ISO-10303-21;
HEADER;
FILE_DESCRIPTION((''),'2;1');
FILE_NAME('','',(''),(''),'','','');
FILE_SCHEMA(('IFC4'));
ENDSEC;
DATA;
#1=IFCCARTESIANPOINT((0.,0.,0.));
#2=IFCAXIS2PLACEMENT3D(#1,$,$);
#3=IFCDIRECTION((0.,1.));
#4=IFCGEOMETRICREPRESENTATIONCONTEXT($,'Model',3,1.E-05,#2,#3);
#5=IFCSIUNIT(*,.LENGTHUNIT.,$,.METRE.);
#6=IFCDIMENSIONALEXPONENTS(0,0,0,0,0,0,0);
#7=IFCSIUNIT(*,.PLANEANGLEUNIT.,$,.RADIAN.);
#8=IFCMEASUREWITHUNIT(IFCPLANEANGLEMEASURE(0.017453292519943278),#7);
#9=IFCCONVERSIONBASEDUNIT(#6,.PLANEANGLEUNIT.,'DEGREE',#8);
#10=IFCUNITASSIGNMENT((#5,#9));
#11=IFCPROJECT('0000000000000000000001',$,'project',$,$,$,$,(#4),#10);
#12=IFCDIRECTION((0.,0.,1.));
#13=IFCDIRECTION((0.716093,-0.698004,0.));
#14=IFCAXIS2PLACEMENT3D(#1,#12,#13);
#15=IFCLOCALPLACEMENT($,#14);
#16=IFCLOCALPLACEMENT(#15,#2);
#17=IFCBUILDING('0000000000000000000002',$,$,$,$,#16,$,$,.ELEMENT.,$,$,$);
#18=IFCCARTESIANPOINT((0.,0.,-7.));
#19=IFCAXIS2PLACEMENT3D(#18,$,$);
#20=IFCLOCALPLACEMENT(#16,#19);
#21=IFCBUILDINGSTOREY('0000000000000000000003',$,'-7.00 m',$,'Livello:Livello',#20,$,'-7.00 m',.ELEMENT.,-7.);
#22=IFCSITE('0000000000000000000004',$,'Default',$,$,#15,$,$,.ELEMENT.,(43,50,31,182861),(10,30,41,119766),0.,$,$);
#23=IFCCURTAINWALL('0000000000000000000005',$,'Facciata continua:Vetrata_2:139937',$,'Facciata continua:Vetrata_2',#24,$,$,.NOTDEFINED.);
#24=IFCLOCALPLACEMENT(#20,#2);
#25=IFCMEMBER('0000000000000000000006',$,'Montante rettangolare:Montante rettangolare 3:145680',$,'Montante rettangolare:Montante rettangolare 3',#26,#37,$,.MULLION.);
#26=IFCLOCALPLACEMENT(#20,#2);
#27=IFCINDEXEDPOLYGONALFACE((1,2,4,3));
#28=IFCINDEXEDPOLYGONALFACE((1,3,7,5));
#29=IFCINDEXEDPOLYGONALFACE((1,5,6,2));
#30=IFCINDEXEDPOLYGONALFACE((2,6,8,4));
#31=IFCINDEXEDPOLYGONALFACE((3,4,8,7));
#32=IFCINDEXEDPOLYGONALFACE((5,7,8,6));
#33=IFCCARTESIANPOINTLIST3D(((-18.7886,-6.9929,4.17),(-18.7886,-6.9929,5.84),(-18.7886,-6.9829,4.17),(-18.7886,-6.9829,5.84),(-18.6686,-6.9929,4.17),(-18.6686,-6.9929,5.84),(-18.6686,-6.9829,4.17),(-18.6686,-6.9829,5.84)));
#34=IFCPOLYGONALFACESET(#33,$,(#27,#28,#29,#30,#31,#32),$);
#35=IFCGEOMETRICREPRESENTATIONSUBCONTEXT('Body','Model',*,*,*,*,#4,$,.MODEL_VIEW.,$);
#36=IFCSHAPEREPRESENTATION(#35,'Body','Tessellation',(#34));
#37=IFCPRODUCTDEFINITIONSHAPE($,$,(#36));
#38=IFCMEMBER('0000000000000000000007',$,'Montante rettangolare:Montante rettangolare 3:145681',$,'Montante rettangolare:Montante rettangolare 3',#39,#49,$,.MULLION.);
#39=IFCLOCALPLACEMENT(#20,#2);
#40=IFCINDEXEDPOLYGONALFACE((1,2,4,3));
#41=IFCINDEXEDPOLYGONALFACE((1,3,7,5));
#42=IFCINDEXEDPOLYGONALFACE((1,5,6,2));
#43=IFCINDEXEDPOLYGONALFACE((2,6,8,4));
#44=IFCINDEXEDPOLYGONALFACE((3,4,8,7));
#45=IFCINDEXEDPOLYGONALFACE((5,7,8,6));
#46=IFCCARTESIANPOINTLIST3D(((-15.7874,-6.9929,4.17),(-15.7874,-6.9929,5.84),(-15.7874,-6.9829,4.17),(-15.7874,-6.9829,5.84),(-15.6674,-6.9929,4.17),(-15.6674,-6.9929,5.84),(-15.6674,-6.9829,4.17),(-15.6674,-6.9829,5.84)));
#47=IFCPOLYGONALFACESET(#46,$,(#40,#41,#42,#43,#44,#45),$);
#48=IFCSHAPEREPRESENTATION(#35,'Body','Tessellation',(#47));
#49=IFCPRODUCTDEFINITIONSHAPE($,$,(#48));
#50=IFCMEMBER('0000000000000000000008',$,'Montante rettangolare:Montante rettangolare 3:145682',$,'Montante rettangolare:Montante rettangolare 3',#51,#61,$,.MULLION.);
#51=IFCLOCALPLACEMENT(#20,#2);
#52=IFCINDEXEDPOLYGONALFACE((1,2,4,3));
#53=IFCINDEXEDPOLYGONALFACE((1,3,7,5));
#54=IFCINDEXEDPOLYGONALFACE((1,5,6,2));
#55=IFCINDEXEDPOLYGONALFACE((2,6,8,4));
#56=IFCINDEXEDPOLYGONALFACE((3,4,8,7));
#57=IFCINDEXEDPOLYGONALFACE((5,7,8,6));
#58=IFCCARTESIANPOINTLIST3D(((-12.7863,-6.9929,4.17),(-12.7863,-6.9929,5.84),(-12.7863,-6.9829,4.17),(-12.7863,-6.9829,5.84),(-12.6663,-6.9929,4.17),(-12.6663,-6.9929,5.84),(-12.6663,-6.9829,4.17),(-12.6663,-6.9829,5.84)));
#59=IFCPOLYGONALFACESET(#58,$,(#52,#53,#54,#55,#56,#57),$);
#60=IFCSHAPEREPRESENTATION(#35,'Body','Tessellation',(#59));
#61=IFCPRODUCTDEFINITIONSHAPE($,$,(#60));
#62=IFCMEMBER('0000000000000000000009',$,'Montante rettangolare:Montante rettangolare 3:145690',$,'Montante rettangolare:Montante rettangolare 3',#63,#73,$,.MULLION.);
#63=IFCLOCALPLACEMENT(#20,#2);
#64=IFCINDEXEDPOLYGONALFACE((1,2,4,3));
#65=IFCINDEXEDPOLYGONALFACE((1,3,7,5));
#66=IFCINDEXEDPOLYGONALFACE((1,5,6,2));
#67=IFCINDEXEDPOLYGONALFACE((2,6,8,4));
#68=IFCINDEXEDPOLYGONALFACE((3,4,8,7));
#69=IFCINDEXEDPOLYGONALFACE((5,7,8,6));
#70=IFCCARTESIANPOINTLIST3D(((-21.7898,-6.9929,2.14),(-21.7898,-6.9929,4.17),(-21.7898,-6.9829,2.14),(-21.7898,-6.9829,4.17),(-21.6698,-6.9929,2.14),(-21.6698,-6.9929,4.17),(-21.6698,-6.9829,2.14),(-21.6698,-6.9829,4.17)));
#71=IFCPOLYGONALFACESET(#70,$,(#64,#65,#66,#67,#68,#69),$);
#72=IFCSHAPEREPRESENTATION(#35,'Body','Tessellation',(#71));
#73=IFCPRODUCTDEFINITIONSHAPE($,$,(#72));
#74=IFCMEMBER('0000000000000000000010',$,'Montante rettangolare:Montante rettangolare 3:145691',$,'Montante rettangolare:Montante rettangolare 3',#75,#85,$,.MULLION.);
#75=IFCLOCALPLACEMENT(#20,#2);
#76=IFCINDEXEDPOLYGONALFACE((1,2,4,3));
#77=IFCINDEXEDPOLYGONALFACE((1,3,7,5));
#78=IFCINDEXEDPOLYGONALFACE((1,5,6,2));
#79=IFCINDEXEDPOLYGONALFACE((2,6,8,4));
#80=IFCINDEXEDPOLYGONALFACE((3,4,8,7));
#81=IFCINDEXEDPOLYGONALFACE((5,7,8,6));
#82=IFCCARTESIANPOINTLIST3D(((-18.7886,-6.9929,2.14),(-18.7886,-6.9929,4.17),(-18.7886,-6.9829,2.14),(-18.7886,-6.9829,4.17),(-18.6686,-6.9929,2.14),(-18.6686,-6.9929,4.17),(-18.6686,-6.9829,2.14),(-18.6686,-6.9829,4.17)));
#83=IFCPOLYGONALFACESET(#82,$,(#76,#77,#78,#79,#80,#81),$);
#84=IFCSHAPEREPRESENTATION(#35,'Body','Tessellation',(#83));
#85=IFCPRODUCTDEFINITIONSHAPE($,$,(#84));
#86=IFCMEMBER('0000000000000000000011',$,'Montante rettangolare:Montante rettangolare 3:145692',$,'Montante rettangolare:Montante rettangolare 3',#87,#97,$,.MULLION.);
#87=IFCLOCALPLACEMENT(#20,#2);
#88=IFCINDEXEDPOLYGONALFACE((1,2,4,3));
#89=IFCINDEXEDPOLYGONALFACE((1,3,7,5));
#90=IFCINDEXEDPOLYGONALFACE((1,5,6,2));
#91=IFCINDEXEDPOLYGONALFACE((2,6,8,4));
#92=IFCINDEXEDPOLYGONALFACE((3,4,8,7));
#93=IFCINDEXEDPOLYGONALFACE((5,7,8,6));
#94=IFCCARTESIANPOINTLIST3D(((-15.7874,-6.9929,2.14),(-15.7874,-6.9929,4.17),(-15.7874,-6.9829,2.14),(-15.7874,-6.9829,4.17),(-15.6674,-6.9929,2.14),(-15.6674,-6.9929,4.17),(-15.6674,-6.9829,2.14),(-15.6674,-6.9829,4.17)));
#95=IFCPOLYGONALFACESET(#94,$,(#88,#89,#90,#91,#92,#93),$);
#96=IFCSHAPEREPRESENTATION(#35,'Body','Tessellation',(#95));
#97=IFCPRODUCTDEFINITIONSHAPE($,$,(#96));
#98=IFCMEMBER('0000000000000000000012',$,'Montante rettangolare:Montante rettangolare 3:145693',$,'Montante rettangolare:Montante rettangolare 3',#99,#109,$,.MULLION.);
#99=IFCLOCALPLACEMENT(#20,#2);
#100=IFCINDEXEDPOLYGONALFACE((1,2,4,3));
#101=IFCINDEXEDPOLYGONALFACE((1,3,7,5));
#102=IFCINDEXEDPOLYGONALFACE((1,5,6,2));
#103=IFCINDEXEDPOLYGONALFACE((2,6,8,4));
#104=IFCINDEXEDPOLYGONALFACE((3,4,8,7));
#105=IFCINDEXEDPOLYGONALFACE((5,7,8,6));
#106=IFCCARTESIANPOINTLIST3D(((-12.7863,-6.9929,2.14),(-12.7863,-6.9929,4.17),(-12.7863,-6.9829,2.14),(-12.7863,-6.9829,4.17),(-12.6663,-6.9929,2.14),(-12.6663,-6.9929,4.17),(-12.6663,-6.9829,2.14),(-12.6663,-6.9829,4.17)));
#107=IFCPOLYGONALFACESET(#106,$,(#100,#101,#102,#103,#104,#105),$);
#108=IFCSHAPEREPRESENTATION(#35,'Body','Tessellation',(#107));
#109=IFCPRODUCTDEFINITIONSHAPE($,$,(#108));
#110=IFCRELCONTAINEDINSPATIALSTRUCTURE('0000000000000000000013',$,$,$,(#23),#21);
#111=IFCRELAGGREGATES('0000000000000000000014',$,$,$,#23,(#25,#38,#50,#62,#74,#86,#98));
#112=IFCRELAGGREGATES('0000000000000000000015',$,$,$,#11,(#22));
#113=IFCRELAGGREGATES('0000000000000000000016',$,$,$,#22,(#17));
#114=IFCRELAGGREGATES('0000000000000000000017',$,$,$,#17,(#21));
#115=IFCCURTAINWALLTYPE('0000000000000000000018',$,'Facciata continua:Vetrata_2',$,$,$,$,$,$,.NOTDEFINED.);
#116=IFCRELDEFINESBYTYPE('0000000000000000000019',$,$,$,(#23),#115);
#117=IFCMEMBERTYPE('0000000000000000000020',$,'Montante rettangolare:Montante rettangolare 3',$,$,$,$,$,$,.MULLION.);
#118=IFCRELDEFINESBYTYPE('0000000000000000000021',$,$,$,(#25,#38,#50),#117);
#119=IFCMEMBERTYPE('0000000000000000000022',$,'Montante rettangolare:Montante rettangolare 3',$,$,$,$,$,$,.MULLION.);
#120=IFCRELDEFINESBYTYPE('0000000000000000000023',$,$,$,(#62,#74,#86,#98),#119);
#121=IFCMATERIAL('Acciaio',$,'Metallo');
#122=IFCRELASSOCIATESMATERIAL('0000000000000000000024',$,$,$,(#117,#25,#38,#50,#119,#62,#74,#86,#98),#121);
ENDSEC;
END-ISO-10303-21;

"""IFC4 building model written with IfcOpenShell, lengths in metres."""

from ifc_helpers import new_model, entity, si_unit, converted_unit, direction, frame, origin, place, context, subcontext, project, spatial, indexed_curve, outline, extrude, source, transform, mapped, material, type_object, type_shapes, element, aggregate, save


model = new_model("IFC4")

# Units and contexts
model_context = context("Model", 3, precision=1e-05, world=origin(), true_north=direction((0.0, 1.0)))
body_context = subcontext(model_context, "Body", "Model", "MODEL_VIEW")
ifc_project = project(units=[si_unit("LENGTHUNIT", "METRE"), converted_unit("PLANEANGLEUNIT", "DEGREE", entity("IfcPlaneAngleMeasure", 0.017453292519943278), si_unit("PLANEANGLEUNIT", "RADIAN"), dimensions=[0, 0, 0, 0, 0, 0, 0])], contexts=[model_context])

# Site, building, storey
site_placement = place(None, frame((0.0, 0.0, 0.0), z_axis=(0.0, 0.0, 1.0), x_axis=(0.716093, -0.698004, 0.0)))
site = spatial("IfcSite", under=ifc_project, at=site_placement, Name="Default", CompositionType="ELEMENT", RefLatitude=(43, 50, 31, 182861), RefLongitude=(10, 30, 41, 119766), RefElevation=0.0)
building_placement = place(site_placement, origin())
building = spatial("IfcBuilding", under=site, at=building_placement, CompositionType="ELEMENT")
storey_placement = place(building_placement, frame((0.0, 0.0, -7.0)))
storey = spatial("IfcBuildingStorey", under=building, at=storey_placement, Name="-7.00 m", ObjectType="Livello:Livello", LongName="-7.00 m", CompositionType="ELEMENT", Elevation=-7.0)

# Curtain wall, members
curtain_wall_type = type_object("IfcCurtainWallType", Name="Facciata continua:Vetrata_2", PredefinedType="NOTDEFINED")
curtain_wall_placement = place(storey_placement, frame((0.0, 0.0, 7.0)))
curtain_wall = element("IfcCurtainWall", 1, at=curtain_wall_placement, inside=storey, type_object=curtain_wall_type, Name="Facciata continua:Vetrata_2:139937", ObjectType="Facciata continua:Vetrata_2", PredefinedType="NOTDEFINED")
ifc_material = material(Name="Acciaio", Category="Metallo")
member_type_1 = type_object("IfcMemberType", Name="Montante rettangolare:Montante rettangolare 3", PredefinedType="MULLION", material=ifc_material)
shared_shape_1 = source(origin(), body_context, "Body", "SweptSolid", [
    extrude(outline(indexed_curve([(-0.06, -0.005), (0.06, -0.005), (0.06, 0.005), (-0.06, 0.005), (-0.06, -0.005)], self_intersect=False)), frame((0.0, 0.01, -1.67), z_axis=(0.0, 0.0, 1.0), x_axis=(-1.0, 0.0, 0.0)), (0.0, 0.0, 1.0), 1.67),
])
type_shapes(member_type_1, [shared_shape_1])
member_1_placement = place(curtain_wall_placement, frame((-18.7286, -6.9779, -2.83), z_axis=(0.0, 0.0, -1.0), x_axis=(1.0, 0.0, 0.0)))
member_1 = element("IfcMember", 2, at=member_1_placement, type_object=member_type_1, material=ifc_material, Name="Montante rettangolare:Montante rettangolare 3:145680", ObjectType="Montante rettangolare:Montante rettangolare 3", PredefinedType="MULLION", context=body_context, shape_type="MappedRepresentation", body=[
    mapped(shared_shape_1, transform((0.0, 0.0, 0.0), scale=1.0)),
])
member_2_placement = place(curtain_wall_placement, frame((-15.7274, -6.9779, -2.83), z_axis=(0.0, 0.0, -1.0), x_axis=(1.0, 0.0, 0.0)))
member_2 = element("IfcMember", 3, at=member_2_placement, type_object=member_type_1, material=ifc_material, Name="Montante rettangolare:Montante rettangolare 3:145681", ObjectType="Montante rettangolare:Montante rettangolare 3", PredefinedType="MULLION", context=body_context, shape_type="MappedRepresentation", body=[
    mapped(shared_shape_1, transform((0.0, 0.0, 0.0), scale=1.0)),
])
member_3_placement = place(curtain_wall_placement, frame((-12.7263, -6.9779, -2.83), z_axis=(0.0, 0.0, -1.0), x_axis=(1.0, 0.0, 0.0)))
member_3 = element("IfcMember", 4, at=member_3_placement, type_object=member_type_1, material=ifc_material, Name="Montante rettangolare:Montante rettangolare 3:145682", ObjectType="Montante rettangolare:Montante rettangolare 3", PredefinedType="MULLION", context=body_context, shape_type="MappedRepresentation", body=[
    mapped(shared_shape_1, transform((0.0, 0.0, 0.0), scale=1.0)),
])
member_type_2 = type_object("IfcMemberType", Name="Montante rettangolare:Montante rettangolare 3", PredefinedType="MULLION", material=ifc_material)
shared_shape_2 = source(origin(), body_context, "Body", "SweptSolid", [
    extrude(outline(indexed_curve([(-0.06, -0.005), (0.06, -0.005), (0.06, 0.005), (-0.06, 0.005), (-0.06, -0.005)], self_intersect=False)), frame((0.0, 0.01, -2.03), z_axis=(0.0, 0.0, 1.0), x_axis=(-1.0, 0.0, 0.0)), (0.0, 0.0, 1.0), 2.03),
])
type_shapes(member_type_2, [shared_shape_2])
member_4_placement = place(curtain_wall_placement, frame((-21.7298, -6.9779, -4.86), z_axis=(0.0, 0.0, -1.0), x_axis=(1.0, 0.0, 0.0)))
member_4 = element("IfcMember", 5, at=member_4_placement, type_object=member_type_2, material=ifc_material, Name="Montante rettangolare:Montante rettangolare 3:145690", ObjectType="Montante rettangolare:Montante rettangolare 3", PredefinedType="MULLION", context=body_context, shape_type="MappedRepresentation", body=[
    mapped(shared_shape_2, transform((0.0, 0.0, 0.0), scale=1.0)),
])
member_5_placement = place(curtain_wall_placement, frame((-18.7286, -6.9779, -4.86), z_axis=(0.0, 0.0, -1.0), x_axis=(1.0, 0.0, 0.0)))
member_5 = element("IfcMember", 6, at=member_5_placement, type_object=member_type_2, material=ifc_material, Name="Montante rettangolare:Montante rettangolare 3:145691", ObjectType="Montante rettangolare:Montante rettangolare 3", PredefinedType="MULLION", context=body_context, shape_type="MappedRepresentation", body=[
    mapped(shared_shape_2, transform((0.0, 0.0, 0.0), scale=1.0)),
])
member_6_placement = place(curtain_wall_placement, frame((-15.7274, -6.9779, -4.86), z_axis=(0.0, 0.0, -1.0), x_axis=(1.0, 0.0, 0.0)))
member_6 = element("IfcMember", 7, at=member_6_placement, type_object=member_type_2, material=ifc_material, Name="Montante rettangolare:Montante rettangolare 3:145692", ObjectType="Montante rettangolare:Montante rettangolare 3", PredefinedType="MULLION", context=body_context, shape_type="MappedRepresentation", body=[
    mapped(shared_shape_2, transform((0.0, 0.0, 0.0), scale=1.0)),
])
member_7_placement = place(curtain_wall_placement, frame((-12.7263, -6.9779, -4.86), z_axis=(0.0, 0.0, -1.0), x_axis=(1.0, 0.0, 0.0)))
member_7 = element("IfcMember", 8, at=member_7_placement, type_object=member_type_2, material=ifc_material, Name="Montante rettangolare:Montante rettangolare 3:145693", ObjectType="Montante rettangolare:Montante rettangolare 3", PredefinedType="MULLION", context=body_context, shape_type="MappedRepresentation", body=[
    mapped(shared_shape_2, transform((0.0, 0.0, 0.0), scale=1.0)),
])
aggregate(curtain_wall, [member_1, member_2, member_3, member_4, member_5, member_6, member_7])

save(model, "model.ifc")
